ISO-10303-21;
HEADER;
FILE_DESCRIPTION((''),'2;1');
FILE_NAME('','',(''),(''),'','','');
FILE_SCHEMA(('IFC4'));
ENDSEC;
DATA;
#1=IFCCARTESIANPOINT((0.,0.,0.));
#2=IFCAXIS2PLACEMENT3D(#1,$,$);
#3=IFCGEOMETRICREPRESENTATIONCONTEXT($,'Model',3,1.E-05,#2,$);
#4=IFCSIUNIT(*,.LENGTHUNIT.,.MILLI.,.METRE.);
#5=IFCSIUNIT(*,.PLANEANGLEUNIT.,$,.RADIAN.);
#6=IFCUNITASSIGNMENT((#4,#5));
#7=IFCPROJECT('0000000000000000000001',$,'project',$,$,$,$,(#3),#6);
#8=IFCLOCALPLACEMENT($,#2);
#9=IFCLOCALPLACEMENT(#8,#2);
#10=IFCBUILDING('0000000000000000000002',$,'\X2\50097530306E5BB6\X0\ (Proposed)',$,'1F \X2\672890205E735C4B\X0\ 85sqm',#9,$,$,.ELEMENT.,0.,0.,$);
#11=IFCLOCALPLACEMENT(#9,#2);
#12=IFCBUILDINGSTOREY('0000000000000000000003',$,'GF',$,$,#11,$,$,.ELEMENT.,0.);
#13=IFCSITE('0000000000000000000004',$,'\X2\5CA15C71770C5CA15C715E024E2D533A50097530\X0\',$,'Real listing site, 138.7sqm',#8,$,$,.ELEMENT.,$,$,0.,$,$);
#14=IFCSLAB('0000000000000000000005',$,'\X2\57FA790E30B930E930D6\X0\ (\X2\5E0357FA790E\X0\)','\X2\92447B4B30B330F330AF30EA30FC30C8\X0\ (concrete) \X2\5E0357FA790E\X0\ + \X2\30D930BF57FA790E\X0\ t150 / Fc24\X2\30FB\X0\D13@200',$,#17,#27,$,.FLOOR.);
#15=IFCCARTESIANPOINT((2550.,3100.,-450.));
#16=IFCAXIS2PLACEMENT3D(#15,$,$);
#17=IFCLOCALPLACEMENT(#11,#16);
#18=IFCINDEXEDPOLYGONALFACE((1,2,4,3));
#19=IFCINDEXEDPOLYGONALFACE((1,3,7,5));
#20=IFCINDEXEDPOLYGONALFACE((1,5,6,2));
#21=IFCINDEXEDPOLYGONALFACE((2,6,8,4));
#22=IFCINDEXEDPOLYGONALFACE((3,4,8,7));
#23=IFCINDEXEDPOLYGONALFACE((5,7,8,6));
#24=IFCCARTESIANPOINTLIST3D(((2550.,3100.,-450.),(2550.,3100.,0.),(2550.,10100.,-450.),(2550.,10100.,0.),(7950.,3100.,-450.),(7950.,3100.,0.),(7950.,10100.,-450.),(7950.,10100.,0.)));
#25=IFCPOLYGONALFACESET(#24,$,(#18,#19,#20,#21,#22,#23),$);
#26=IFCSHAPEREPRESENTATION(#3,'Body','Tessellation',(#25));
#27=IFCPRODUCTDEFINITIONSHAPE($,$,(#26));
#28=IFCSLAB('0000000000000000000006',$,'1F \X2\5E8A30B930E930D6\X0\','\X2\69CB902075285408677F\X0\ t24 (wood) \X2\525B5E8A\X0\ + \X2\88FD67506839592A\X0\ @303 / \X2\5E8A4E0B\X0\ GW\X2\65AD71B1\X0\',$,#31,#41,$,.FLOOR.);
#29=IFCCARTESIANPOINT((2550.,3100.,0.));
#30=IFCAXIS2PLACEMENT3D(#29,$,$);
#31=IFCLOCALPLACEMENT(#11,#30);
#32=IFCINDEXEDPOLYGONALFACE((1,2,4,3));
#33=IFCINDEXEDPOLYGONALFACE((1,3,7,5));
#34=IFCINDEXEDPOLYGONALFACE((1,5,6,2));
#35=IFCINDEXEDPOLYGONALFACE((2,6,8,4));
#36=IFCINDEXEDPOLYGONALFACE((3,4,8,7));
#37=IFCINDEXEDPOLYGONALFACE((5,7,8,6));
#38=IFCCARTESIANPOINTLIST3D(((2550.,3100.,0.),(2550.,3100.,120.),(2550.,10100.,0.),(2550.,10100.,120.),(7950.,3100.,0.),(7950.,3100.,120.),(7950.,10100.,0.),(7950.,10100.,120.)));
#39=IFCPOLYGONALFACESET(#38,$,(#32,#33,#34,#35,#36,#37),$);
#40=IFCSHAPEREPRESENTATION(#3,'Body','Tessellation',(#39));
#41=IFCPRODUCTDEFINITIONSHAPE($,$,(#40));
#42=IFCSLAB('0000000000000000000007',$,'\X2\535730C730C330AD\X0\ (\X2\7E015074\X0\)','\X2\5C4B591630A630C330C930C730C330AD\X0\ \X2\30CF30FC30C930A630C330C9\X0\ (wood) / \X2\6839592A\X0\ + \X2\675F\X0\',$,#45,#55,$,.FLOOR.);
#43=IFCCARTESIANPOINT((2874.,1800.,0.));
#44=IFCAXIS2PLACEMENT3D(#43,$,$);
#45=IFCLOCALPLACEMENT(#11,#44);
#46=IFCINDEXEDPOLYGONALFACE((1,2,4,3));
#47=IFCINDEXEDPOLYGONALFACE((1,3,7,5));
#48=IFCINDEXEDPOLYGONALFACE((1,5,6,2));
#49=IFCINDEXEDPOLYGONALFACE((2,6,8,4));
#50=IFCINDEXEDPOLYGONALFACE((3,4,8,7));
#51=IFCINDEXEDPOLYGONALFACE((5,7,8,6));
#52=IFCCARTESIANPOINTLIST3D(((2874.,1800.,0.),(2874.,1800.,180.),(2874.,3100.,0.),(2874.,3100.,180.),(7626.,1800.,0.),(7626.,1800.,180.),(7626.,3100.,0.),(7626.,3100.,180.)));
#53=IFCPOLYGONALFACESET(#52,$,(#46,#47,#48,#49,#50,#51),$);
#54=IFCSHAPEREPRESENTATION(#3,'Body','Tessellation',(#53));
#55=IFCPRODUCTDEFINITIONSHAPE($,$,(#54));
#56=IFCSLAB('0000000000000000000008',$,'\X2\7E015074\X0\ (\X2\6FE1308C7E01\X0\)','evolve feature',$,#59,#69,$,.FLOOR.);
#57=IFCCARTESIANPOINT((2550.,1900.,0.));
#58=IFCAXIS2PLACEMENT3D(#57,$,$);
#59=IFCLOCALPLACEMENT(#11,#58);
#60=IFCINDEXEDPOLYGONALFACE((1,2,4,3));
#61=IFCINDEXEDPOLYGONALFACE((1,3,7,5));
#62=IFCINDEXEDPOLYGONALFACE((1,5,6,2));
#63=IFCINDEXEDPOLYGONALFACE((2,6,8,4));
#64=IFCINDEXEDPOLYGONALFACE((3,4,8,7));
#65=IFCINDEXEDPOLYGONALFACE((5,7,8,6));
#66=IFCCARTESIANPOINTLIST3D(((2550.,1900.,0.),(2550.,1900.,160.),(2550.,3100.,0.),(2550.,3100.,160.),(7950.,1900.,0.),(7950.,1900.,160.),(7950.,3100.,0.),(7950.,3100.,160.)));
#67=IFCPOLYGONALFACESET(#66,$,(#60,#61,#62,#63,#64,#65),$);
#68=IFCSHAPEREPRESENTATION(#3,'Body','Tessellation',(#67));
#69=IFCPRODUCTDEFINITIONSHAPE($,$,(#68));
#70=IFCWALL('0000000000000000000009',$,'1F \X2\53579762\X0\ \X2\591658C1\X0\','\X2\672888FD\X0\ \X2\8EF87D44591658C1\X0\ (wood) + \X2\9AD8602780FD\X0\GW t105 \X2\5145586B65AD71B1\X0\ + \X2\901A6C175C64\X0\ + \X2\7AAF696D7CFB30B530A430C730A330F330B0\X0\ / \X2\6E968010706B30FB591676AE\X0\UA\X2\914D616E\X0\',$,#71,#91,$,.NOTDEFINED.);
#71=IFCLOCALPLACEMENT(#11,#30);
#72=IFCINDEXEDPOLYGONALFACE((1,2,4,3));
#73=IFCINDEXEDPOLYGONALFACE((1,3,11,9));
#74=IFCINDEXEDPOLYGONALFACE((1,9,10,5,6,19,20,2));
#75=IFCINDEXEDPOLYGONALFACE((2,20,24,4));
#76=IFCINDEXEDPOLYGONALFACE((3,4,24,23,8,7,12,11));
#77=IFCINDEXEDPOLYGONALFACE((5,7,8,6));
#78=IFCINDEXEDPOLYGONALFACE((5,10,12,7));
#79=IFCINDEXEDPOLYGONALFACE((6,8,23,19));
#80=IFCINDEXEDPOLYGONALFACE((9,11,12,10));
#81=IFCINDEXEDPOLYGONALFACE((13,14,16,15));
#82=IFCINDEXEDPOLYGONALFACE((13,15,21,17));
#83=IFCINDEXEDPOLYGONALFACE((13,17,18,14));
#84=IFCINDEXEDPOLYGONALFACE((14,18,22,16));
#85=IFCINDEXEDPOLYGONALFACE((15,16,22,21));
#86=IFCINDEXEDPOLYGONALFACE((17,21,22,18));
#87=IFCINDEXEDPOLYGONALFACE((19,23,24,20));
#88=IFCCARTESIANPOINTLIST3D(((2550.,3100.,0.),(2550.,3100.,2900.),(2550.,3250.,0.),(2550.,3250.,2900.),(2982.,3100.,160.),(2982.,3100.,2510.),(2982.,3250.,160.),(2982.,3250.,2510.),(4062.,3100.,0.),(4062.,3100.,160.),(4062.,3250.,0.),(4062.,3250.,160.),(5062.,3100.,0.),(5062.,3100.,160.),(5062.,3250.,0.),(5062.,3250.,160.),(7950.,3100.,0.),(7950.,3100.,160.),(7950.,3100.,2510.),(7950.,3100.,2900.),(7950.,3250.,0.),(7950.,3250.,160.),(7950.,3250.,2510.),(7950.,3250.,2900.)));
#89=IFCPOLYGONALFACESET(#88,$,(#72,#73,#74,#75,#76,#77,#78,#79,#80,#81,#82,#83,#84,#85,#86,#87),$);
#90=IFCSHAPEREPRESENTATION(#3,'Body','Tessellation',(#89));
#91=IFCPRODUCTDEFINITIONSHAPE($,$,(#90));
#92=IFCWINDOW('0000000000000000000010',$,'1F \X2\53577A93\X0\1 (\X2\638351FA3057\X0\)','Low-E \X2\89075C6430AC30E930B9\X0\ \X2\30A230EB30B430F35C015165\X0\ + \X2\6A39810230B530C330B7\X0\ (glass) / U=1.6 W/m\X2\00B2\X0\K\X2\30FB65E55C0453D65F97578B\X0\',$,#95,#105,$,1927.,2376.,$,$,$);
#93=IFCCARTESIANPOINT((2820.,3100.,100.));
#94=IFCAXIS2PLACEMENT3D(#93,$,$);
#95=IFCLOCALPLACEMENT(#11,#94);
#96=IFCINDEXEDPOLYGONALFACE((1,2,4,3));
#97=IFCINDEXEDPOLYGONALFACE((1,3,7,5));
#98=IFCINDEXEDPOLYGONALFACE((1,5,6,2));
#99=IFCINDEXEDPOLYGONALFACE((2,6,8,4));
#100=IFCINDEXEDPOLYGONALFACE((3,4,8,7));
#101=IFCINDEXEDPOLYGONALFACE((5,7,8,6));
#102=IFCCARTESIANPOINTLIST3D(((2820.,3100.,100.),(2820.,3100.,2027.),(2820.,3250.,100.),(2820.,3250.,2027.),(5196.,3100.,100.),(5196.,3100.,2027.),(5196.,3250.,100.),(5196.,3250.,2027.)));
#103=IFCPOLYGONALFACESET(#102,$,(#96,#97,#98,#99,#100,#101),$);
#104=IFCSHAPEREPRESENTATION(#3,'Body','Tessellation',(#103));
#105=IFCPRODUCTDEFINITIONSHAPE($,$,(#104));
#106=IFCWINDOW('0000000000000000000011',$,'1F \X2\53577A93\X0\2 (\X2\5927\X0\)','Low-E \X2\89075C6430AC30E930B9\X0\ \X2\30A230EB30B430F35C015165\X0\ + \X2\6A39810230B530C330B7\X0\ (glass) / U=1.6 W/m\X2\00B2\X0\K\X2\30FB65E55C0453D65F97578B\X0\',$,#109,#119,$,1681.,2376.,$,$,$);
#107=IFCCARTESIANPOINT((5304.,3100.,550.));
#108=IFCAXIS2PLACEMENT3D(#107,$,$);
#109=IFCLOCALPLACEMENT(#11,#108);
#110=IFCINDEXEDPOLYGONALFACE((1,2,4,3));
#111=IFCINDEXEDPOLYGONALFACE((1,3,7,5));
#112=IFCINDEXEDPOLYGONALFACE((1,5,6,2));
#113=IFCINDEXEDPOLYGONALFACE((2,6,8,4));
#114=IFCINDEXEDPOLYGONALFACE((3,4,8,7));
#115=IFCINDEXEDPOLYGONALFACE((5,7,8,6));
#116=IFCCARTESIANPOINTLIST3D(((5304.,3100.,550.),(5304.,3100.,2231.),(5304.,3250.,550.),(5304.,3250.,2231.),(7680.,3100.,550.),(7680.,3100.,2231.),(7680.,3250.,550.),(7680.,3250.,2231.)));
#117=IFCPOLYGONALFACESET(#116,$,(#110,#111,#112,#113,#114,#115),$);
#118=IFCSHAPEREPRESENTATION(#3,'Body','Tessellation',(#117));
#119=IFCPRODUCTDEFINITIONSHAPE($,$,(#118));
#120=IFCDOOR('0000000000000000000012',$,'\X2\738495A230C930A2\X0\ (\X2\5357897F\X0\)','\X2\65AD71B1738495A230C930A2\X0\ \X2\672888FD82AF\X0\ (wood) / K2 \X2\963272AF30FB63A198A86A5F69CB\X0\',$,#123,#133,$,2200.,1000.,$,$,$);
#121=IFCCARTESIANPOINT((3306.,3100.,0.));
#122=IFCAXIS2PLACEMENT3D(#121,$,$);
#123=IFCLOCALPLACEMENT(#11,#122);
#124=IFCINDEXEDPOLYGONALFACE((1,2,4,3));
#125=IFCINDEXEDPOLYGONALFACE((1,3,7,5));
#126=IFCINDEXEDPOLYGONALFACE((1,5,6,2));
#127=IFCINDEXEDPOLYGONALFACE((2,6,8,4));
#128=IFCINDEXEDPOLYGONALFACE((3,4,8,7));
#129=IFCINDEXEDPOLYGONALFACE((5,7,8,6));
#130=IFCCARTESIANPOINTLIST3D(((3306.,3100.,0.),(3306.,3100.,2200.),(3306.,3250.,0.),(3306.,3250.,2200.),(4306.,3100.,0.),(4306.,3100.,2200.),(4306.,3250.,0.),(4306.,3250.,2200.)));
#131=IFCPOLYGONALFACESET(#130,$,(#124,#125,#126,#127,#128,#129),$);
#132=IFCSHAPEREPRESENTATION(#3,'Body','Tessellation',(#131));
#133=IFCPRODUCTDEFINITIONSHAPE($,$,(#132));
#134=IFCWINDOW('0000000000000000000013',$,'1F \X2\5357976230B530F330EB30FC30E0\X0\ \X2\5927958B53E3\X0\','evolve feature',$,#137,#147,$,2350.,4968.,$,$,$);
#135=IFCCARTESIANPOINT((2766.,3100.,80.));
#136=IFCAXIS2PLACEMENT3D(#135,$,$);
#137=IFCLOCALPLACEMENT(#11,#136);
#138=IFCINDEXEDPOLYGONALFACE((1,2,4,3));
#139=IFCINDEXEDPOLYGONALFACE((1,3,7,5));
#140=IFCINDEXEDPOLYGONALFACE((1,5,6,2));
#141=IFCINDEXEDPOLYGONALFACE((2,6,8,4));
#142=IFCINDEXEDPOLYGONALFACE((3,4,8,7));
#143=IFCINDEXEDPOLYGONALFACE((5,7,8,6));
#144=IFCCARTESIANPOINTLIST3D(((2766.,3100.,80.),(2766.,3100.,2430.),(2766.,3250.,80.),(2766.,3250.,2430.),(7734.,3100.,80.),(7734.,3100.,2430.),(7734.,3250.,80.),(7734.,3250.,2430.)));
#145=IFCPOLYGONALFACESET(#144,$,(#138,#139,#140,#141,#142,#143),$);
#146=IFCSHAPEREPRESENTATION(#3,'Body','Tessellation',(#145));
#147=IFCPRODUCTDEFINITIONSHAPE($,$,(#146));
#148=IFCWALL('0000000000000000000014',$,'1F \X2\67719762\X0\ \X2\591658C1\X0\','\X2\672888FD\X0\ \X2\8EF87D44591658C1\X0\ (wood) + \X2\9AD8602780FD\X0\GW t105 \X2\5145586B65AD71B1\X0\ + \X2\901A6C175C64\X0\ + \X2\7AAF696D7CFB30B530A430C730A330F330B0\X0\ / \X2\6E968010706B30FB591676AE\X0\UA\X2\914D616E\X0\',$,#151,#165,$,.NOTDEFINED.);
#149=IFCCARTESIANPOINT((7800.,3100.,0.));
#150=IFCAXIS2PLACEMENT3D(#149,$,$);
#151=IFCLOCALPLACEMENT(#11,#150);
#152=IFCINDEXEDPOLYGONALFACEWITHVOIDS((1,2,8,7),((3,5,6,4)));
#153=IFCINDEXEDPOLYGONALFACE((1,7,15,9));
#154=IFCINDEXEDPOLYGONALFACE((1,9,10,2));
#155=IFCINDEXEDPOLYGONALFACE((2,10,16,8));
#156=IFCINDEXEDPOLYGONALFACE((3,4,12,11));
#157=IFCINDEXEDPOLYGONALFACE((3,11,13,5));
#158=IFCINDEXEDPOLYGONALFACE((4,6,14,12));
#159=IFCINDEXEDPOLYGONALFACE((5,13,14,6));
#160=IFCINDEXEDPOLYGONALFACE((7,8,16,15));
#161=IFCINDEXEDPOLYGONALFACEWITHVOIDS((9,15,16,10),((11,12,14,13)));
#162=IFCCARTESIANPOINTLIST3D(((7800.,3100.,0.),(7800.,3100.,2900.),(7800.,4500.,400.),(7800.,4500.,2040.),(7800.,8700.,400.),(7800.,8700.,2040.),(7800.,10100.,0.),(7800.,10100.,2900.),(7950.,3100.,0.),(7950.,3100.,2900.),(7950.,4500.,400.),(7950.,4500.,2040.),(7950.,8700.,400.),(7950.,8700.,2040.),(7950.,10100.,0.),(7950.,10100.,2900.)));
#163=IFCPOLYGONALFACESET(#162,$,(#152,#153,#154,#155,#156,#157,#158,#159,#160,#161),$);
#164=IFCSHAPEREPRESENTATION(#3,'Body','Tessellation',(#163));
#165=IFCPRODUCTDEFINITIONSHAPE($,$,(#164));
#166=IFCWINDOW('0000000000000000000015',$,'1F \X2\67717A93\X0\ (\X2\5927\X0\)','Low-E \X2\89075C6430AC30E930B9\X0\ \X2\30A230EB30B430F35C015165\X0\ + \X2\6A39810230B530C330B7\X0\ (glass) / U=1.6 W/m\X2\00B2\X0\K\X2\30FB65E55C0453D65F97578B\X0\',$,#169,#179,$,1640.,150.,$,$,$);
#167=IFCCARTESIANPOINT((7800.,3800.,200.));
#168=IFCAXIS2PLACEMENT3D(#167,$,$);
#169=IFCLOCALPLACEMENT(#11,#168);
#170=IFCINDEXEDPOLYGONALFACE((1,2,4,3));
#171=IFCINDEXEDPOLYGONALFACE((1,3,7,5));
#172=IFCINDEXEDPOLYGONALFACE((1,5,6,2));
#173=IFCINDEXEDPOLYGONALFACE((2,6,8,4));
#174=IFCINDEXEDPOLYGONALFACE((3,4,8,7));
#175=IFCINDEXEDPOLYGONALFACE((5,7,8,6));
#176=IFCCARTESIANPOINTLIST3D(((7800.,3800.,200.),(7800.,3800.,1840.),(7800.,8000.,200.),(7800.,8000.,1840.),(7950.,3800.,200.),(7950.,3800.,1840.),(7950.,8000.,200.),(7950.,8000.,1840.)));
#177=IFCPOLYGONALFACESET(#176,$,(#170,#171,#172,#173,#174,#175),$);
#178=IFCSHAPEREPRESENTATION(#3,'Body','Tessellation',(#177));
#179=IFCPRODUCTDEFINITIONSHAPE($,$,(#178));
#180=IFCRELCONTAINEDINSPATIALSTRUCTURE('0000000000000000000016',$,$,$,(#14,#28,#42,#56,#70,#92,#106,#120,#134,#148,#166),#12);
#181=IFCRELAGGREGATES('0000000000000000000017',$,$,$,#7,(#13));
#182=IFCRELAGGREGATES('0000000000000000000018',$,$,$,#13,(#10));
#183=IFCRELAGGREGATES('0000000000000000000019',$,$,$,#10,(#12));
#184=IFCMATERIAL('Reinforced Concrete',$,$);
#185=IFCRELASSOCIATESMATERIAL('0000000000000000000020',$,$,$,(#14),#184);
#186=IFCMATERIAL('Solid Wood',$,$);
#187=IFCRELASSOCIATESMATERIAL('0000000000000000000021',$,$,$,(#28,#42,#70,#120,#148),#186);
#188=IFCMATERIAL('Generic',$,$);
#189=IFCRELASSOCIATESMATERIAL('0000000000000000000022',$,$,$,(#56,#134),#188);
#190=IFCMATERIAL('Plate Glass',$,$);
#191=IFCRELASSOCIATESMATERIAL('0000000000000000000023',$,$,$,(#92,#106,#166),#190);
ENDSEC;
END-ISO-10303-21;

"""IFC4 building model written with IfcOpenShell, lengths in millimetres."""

from ifc_helpers import new_model, si_unit, frame, frame_2d, origin, place, context, project, spatial, rectangle, extrude, material, element, fill, save


model = new_model("IFC4")

# Units and contexts
model_context = context("Model", 3, precision=1e-05, world=origin())
ifc_project = project(units=[si_unit("LENGTHUNIT", "METRE", prefix="MILLI"), si_unit("PLANEANGLEUNIT", "RADIAN")], contexts=[model_context])

# Site, building, storey
site_placement = place(None, origin())
site = spatial("IfcSite", under=ifc_project, at=site_placement, Name="岡山県岡山市中区倉田", ObjectType="Real listing site, 138.7sqm", CompositionType="ELEMENT", RefElevation=0.0)
building_placement = place(site_placement, origin())
building = spatial("IfcBuilding", under=site, at=building_placement, Name="倉田の家 (Proposed)", ObjectType="1F 木造平屋 85sqm", CompositionType="ELEMENT", ElevationOfRefHeight=0.0, ElevationOfTerrain=0.0)
storey_placement = place(building_placement, origin())
storey = spatial("IfcBuildingStorey", under=building, at=storey_placement, Name="GF", CompositionType="ELEMENT", Elevation=0.0)

# Slabs
ifc_material_1 = material(Name="Reinforced Concrete")
slab_1_placement = place(storey_placement, frame((2550.0, 3100.0, -450.0)))
element("IfcSlab", 1, at=slab_1_placement, inside=storey, material=ifc_material_1, Name="基礎スラブ (布基礎)", Description="鉄筋コンクリート (concrete) 布基礎 + ベタ基礎 t150 / Fc24・D13@200", PredefinedType="FLOOR", context=model_context, shape_type="SweptSolid", body=[
    extrude(rectangle(XDim=5400.0, YDim=7000.0, at=frame_2d((2700.0, 3500.0))), frame((2550.0, 3100.0, -450.0)), (0.0, 0.0, 1.0), 450.0),
])
ifc_material_2 = material(Name="Solid Wood")
slab_2_placement = place(storey_placement, frame((2550.0, 3100.0, 0.0)))
element("IfcSlab", 2, at=slab_2_placement, inside=storey, material=ifc_material_2, Name="1F 床スラブ", Description="構造用合板 t24 (wood) 剛床 + 製材根太 @303 / 床下 GW断熱", PredefinedType="FLOOR", context=model_context, shape_type="SweptSolid", body=[
    extrude(rectangle(XDim=5400.0, YDim=7000.0, at=frame_2d((2700.0, 3500.0))), frame((2550.0, 3100.0, 0.0)), (0.0, 0.0, 1.0), 120.0),
])
slab_3_placement = place(storey_placement, frame((2874.0, 1800.0, 0.0)))
element("IfcSlab", 3, at=slab_3_placement, inside=storey, material=ifc_material_2, Name="南デッキ (縁側)", Description="屋外ウッドデッキ ハードウッド (wood) / 根太 + 束", PredefinedType="FLOOR", context=model_context, shape_type="SweptSolid", body=[
    extrude(rectangle(XDim=4752.0, YDim=1300.0, at=frame_2d((2376.0, 650.0))), frame((2874.0, 1800.0, 0.0)), (0.0, 0.0, 1.0), 180.0),
])
ifc_material_3 = material(Name="Generic")
slab_4_placement = place(storey_placement, frame((2550.0, 1900.0, 0.0)))
element("IfcSlab", 4, at=slab_4_placement, inside=storey, material=ifc_material_3, Name="縁側 (濡れ縁)", Description="evolve feature", PredefinedType="FLOOR", context=model_context, shape_type="SweptSolid", body=[
    extrude(rectangle(XDim=5400.0, YDim=1200.0, at=frame_2d((2700.0, 600.0))), frame((2550.0, 1900.0, 0.0)), (0.0, 0.0, 1.0), 160.0),
])

# Wall, openings, windows, door
wall_1_placement = place(storey_placement, frame((2550.0, 3100.0, 0.0)))
wall_1 = element("IfcWall", 5, at=wall_1_placement, inside=storey, material=ifc_material_2, Name="1F 南面 外壁", Description="木製 軸組外壁 (wood) + 高性能GW t105 充填断熱 + 通気層 + 窯業系サイディング / 準耐火・外皮UA配慮", PredefinedType="NOTDEFINED", context=model_context, shape_type="SweptSolid", body=[
    extrude(rectangle(XDim=5400.0, YDim=150.0, at=frame_2d((2700.0, 75.0))), frame((2550.0, 3100.0, 0.0)), (0.0, 0.0, 1.0), 2900.0),
])
opening_1_placement = place(storey_placement, frame((2820.0, 3100.0, 100.0)))
opening_1 = element("IfcOpeningElement", 6, at=opening_1_placement, cuts=wall_1, PredefinedType="NOTDEFINED", context=model_context, shape_type="SweptSolid", body=[
    extrude(rectangle(XDim=2376.0, YDim=150.0, at=frame_2d((1188.0, 75.0))), frame((2820.0, 3100.0, 100.0)), (0.0, 0.0, 1.0), 1927.0),
])
opening_2_placement = place(storey_placement, frame((5304.0, 3100.0, 550.0)))
opening_2 = element("IfcOpeningElement", 7, at=opening_2_placement, cuts=wall_1, PredefinedType="NOTDEFINED", context=model_context, shape_type="SweptSolid", body=[
    extrude(rectangle(XDim=2376.0, YDim=150.0, at=frame_2d((1188.0, 75.0))), frame((5304.0, 3100.0, 550.0)), (0.0, 0.0, 1.0), 1681.0),
])
opening_3_placement = place(storey_placement, frame((3306.0, 3100.0, 0.0)))
opening_3 = element("IfcOpeningElement", 8, at=opening_3_placement, cuts=wall_1, PredefinedType="NOTDEFINED", context=model_context, shape_type="SweptSolid", body=[
    extrude(rectangle(XDim=1000.0, YDim=150.0, at=frame_2d((500.0, 75.0))), frame((3306.0, 3100.0, 0.0)), (0.0, 0.0, 1.0), 2200.0),
])
opening_4_placement = place(storey_placement, frame((2766.0, 3100.0, 80.0)))
opening_4 = element("IfcOpeningElement", 9, at=opening_4_placement, cuts=wall_1, PredefinedType="NOTDEFINED", context=model_context, shape_type="SweptSolid", body=[
    extrude(rectangle(XDim=4968.0, YDim=150.0, at=frame_2d((2484.0, 75.0))), frame((2766.0, 3100.0, 80.0)), (0.0, 0.0, 1.0), 2350.0),
])
ifc_material_4 = material(Name="Plate Glass")
window_1_placement = place(storey_placement, frame((2820.0, 3100.0, 100.0)))
window_1 = element("IfcWindow", 10, at=window_1_placement, inside=storey, material=ifc_material_4, Name="1F 南窓1 (掃出し)", Description="Low-E 複層ガラス アルゴン封入 + 樹脂サッシ (glass) / U=1.6 W/m²K・日射取得型", OverallHeight=1927.0, OverallWidth=2376.0, context=model_context, shape_type="SweptSolid", body=[
    extrude(rectangle(XDim=2376.0, YDim=150.0, at=frame_2d((1188.0, 75.0))), frame((2820.0, 3100.0, 100.0)), (0.0, 0.0, 1.0), 1927.0),
])
fill(opening_1, window_1)
window_2_placement = place(storey_placement, frame((5304.0, 3100.0, 550.0)))
window_2 = element("IfcWindow", 11, at=window_2_placement, inside=storey, material=ifc_material_4, Name="1F 南窓2 (大)", Description="Low-E 複層ガラス アルゴン封入 + 樹脂サッシ (glass) / U=1.6 W/m²K・日射取得型", OverallHeight=1681.0, OverallWidth=2376.0, context=model_context, shape_type="SweptSolid", body=[
    extrude(rectangle(XDim=2376.0, YDim=150.0, at=frame_2d((1188.0, 75.0))), frame((5304.0, 3100.0, 550.0)), (0.0, 0.0, 1.0), 1681.0),
])
fill(opening_2, window_2)
door_placement = place(storey_placement, frame((3306.0, 3100.0, 0.0)))
door = element("IfcDoor", 12, at=door_placement, inside=storey, material=ifc_material_2, Name="玄関ドア (南西)", Description="断熱玄関ドア 木製芯 (wood) / K2 防犯・採風機構", OverallHeight=2200.0, OverallWidth=1000.0, context=model_context, shape_type="SweptSolid", body=[
    extrude(rectangle(XDim=1000.0, YDim=150.0, at=frame_2d((500.0, 75.0))), frame((3306.0, 3100.0, 0.0)), (0.0, 0.0, 1.0), 2200.0),
])
fill(opening_3, door)
window_3_placement = place(storey_placement, frame((2766.0, 3100.0, 80.0)))
window_3 = element("IfcWindow", 13, at=window_3_placement, inside=storey, material=ifc_material_3, Name="1F 南面サンルーム 大開口", Description="evolve feature", OverallHeight=2350.0, OverallWidth=4968.0, context=model_context, shape_type="SweptSolid", body=[
    extrude(rectangle(XDim=4968.0, YDim=150.0, at=frame_2d((2484.0, 75.0))), frame((2766.0, 3100.0, 80.0)), (0.0, 0.0, 1.0), 2350.0),
])
fill(opening_4, window_3)

# Wall, opening, window
wall_2_placement = place(storey_placement, frame((7800.0, 3100.0, 0.0)))
wall_2 = element("IfcWall", 14, at=wall_2_placement, inside=storey, material=ifc_material_2, Name="1F 東面 外壁", Description="木製 軸組外壁 (wood) + 高性能GW t105 充填断熱 + 通気層 + 窯業系サイディング / 準耐火・外皮UA配慮", PredefinedType="NOTDEFINED", context=model_context, shape_type="SweptSolid", body=[
    extrude(rectangle(XDim=150.0, YDim=7000.0, at=frame_2d((75.0, 3500.0))), frame((7800.0, 3100.0, 0.0)), (0.0, 0.0, 1.0), 2900.0),
])
opening_5_placement = place(storey_placement, frame((7800.0, 3800.0, 200.0)))
opening_5 = element("IfcOpeningElement", 15, at=opening_5_placement, cuts=wall_2, PredefinedType="NOTDEFINED", context=model_context, shape_type="SweptSolid", body=[
    extrude(rectangle(XDim=150.0, YDim=4200.0, at=frame_2d((75.0, 2100.0))), frame((7800.0, 3800.0, 200.0)), (0.0, 0.0, 1.0), 1640.0),
])
window_4_placement = place(storey_placement, frame((7800.0, 3800.0, 200.0)))
window_4 = element("IfcWindow", 16, at=window_4_placement, inside=storey, material=ifc_material_4, Name="1F 東窓 (大)", Description="Low-E 複層ガラス アルゴン封入 + 樹脂サッシ (glass) / U=1.6 W/m²K・日射取得型", OverallHeight=1640.0, OverallWidth=150.0, context=model_context, shape_type="SweptSolid", body=[
    extrude(rectangle(XDim=150.0, YDim=4200.0, at=frame_2d((75.0, 2100.0))), frame((7800.0, 3800.0, 200.0)), (0.0, 0.0, 1.0), 1640.0),
])
fill(opening_5, window_4)

save(model, "model.ifc")
